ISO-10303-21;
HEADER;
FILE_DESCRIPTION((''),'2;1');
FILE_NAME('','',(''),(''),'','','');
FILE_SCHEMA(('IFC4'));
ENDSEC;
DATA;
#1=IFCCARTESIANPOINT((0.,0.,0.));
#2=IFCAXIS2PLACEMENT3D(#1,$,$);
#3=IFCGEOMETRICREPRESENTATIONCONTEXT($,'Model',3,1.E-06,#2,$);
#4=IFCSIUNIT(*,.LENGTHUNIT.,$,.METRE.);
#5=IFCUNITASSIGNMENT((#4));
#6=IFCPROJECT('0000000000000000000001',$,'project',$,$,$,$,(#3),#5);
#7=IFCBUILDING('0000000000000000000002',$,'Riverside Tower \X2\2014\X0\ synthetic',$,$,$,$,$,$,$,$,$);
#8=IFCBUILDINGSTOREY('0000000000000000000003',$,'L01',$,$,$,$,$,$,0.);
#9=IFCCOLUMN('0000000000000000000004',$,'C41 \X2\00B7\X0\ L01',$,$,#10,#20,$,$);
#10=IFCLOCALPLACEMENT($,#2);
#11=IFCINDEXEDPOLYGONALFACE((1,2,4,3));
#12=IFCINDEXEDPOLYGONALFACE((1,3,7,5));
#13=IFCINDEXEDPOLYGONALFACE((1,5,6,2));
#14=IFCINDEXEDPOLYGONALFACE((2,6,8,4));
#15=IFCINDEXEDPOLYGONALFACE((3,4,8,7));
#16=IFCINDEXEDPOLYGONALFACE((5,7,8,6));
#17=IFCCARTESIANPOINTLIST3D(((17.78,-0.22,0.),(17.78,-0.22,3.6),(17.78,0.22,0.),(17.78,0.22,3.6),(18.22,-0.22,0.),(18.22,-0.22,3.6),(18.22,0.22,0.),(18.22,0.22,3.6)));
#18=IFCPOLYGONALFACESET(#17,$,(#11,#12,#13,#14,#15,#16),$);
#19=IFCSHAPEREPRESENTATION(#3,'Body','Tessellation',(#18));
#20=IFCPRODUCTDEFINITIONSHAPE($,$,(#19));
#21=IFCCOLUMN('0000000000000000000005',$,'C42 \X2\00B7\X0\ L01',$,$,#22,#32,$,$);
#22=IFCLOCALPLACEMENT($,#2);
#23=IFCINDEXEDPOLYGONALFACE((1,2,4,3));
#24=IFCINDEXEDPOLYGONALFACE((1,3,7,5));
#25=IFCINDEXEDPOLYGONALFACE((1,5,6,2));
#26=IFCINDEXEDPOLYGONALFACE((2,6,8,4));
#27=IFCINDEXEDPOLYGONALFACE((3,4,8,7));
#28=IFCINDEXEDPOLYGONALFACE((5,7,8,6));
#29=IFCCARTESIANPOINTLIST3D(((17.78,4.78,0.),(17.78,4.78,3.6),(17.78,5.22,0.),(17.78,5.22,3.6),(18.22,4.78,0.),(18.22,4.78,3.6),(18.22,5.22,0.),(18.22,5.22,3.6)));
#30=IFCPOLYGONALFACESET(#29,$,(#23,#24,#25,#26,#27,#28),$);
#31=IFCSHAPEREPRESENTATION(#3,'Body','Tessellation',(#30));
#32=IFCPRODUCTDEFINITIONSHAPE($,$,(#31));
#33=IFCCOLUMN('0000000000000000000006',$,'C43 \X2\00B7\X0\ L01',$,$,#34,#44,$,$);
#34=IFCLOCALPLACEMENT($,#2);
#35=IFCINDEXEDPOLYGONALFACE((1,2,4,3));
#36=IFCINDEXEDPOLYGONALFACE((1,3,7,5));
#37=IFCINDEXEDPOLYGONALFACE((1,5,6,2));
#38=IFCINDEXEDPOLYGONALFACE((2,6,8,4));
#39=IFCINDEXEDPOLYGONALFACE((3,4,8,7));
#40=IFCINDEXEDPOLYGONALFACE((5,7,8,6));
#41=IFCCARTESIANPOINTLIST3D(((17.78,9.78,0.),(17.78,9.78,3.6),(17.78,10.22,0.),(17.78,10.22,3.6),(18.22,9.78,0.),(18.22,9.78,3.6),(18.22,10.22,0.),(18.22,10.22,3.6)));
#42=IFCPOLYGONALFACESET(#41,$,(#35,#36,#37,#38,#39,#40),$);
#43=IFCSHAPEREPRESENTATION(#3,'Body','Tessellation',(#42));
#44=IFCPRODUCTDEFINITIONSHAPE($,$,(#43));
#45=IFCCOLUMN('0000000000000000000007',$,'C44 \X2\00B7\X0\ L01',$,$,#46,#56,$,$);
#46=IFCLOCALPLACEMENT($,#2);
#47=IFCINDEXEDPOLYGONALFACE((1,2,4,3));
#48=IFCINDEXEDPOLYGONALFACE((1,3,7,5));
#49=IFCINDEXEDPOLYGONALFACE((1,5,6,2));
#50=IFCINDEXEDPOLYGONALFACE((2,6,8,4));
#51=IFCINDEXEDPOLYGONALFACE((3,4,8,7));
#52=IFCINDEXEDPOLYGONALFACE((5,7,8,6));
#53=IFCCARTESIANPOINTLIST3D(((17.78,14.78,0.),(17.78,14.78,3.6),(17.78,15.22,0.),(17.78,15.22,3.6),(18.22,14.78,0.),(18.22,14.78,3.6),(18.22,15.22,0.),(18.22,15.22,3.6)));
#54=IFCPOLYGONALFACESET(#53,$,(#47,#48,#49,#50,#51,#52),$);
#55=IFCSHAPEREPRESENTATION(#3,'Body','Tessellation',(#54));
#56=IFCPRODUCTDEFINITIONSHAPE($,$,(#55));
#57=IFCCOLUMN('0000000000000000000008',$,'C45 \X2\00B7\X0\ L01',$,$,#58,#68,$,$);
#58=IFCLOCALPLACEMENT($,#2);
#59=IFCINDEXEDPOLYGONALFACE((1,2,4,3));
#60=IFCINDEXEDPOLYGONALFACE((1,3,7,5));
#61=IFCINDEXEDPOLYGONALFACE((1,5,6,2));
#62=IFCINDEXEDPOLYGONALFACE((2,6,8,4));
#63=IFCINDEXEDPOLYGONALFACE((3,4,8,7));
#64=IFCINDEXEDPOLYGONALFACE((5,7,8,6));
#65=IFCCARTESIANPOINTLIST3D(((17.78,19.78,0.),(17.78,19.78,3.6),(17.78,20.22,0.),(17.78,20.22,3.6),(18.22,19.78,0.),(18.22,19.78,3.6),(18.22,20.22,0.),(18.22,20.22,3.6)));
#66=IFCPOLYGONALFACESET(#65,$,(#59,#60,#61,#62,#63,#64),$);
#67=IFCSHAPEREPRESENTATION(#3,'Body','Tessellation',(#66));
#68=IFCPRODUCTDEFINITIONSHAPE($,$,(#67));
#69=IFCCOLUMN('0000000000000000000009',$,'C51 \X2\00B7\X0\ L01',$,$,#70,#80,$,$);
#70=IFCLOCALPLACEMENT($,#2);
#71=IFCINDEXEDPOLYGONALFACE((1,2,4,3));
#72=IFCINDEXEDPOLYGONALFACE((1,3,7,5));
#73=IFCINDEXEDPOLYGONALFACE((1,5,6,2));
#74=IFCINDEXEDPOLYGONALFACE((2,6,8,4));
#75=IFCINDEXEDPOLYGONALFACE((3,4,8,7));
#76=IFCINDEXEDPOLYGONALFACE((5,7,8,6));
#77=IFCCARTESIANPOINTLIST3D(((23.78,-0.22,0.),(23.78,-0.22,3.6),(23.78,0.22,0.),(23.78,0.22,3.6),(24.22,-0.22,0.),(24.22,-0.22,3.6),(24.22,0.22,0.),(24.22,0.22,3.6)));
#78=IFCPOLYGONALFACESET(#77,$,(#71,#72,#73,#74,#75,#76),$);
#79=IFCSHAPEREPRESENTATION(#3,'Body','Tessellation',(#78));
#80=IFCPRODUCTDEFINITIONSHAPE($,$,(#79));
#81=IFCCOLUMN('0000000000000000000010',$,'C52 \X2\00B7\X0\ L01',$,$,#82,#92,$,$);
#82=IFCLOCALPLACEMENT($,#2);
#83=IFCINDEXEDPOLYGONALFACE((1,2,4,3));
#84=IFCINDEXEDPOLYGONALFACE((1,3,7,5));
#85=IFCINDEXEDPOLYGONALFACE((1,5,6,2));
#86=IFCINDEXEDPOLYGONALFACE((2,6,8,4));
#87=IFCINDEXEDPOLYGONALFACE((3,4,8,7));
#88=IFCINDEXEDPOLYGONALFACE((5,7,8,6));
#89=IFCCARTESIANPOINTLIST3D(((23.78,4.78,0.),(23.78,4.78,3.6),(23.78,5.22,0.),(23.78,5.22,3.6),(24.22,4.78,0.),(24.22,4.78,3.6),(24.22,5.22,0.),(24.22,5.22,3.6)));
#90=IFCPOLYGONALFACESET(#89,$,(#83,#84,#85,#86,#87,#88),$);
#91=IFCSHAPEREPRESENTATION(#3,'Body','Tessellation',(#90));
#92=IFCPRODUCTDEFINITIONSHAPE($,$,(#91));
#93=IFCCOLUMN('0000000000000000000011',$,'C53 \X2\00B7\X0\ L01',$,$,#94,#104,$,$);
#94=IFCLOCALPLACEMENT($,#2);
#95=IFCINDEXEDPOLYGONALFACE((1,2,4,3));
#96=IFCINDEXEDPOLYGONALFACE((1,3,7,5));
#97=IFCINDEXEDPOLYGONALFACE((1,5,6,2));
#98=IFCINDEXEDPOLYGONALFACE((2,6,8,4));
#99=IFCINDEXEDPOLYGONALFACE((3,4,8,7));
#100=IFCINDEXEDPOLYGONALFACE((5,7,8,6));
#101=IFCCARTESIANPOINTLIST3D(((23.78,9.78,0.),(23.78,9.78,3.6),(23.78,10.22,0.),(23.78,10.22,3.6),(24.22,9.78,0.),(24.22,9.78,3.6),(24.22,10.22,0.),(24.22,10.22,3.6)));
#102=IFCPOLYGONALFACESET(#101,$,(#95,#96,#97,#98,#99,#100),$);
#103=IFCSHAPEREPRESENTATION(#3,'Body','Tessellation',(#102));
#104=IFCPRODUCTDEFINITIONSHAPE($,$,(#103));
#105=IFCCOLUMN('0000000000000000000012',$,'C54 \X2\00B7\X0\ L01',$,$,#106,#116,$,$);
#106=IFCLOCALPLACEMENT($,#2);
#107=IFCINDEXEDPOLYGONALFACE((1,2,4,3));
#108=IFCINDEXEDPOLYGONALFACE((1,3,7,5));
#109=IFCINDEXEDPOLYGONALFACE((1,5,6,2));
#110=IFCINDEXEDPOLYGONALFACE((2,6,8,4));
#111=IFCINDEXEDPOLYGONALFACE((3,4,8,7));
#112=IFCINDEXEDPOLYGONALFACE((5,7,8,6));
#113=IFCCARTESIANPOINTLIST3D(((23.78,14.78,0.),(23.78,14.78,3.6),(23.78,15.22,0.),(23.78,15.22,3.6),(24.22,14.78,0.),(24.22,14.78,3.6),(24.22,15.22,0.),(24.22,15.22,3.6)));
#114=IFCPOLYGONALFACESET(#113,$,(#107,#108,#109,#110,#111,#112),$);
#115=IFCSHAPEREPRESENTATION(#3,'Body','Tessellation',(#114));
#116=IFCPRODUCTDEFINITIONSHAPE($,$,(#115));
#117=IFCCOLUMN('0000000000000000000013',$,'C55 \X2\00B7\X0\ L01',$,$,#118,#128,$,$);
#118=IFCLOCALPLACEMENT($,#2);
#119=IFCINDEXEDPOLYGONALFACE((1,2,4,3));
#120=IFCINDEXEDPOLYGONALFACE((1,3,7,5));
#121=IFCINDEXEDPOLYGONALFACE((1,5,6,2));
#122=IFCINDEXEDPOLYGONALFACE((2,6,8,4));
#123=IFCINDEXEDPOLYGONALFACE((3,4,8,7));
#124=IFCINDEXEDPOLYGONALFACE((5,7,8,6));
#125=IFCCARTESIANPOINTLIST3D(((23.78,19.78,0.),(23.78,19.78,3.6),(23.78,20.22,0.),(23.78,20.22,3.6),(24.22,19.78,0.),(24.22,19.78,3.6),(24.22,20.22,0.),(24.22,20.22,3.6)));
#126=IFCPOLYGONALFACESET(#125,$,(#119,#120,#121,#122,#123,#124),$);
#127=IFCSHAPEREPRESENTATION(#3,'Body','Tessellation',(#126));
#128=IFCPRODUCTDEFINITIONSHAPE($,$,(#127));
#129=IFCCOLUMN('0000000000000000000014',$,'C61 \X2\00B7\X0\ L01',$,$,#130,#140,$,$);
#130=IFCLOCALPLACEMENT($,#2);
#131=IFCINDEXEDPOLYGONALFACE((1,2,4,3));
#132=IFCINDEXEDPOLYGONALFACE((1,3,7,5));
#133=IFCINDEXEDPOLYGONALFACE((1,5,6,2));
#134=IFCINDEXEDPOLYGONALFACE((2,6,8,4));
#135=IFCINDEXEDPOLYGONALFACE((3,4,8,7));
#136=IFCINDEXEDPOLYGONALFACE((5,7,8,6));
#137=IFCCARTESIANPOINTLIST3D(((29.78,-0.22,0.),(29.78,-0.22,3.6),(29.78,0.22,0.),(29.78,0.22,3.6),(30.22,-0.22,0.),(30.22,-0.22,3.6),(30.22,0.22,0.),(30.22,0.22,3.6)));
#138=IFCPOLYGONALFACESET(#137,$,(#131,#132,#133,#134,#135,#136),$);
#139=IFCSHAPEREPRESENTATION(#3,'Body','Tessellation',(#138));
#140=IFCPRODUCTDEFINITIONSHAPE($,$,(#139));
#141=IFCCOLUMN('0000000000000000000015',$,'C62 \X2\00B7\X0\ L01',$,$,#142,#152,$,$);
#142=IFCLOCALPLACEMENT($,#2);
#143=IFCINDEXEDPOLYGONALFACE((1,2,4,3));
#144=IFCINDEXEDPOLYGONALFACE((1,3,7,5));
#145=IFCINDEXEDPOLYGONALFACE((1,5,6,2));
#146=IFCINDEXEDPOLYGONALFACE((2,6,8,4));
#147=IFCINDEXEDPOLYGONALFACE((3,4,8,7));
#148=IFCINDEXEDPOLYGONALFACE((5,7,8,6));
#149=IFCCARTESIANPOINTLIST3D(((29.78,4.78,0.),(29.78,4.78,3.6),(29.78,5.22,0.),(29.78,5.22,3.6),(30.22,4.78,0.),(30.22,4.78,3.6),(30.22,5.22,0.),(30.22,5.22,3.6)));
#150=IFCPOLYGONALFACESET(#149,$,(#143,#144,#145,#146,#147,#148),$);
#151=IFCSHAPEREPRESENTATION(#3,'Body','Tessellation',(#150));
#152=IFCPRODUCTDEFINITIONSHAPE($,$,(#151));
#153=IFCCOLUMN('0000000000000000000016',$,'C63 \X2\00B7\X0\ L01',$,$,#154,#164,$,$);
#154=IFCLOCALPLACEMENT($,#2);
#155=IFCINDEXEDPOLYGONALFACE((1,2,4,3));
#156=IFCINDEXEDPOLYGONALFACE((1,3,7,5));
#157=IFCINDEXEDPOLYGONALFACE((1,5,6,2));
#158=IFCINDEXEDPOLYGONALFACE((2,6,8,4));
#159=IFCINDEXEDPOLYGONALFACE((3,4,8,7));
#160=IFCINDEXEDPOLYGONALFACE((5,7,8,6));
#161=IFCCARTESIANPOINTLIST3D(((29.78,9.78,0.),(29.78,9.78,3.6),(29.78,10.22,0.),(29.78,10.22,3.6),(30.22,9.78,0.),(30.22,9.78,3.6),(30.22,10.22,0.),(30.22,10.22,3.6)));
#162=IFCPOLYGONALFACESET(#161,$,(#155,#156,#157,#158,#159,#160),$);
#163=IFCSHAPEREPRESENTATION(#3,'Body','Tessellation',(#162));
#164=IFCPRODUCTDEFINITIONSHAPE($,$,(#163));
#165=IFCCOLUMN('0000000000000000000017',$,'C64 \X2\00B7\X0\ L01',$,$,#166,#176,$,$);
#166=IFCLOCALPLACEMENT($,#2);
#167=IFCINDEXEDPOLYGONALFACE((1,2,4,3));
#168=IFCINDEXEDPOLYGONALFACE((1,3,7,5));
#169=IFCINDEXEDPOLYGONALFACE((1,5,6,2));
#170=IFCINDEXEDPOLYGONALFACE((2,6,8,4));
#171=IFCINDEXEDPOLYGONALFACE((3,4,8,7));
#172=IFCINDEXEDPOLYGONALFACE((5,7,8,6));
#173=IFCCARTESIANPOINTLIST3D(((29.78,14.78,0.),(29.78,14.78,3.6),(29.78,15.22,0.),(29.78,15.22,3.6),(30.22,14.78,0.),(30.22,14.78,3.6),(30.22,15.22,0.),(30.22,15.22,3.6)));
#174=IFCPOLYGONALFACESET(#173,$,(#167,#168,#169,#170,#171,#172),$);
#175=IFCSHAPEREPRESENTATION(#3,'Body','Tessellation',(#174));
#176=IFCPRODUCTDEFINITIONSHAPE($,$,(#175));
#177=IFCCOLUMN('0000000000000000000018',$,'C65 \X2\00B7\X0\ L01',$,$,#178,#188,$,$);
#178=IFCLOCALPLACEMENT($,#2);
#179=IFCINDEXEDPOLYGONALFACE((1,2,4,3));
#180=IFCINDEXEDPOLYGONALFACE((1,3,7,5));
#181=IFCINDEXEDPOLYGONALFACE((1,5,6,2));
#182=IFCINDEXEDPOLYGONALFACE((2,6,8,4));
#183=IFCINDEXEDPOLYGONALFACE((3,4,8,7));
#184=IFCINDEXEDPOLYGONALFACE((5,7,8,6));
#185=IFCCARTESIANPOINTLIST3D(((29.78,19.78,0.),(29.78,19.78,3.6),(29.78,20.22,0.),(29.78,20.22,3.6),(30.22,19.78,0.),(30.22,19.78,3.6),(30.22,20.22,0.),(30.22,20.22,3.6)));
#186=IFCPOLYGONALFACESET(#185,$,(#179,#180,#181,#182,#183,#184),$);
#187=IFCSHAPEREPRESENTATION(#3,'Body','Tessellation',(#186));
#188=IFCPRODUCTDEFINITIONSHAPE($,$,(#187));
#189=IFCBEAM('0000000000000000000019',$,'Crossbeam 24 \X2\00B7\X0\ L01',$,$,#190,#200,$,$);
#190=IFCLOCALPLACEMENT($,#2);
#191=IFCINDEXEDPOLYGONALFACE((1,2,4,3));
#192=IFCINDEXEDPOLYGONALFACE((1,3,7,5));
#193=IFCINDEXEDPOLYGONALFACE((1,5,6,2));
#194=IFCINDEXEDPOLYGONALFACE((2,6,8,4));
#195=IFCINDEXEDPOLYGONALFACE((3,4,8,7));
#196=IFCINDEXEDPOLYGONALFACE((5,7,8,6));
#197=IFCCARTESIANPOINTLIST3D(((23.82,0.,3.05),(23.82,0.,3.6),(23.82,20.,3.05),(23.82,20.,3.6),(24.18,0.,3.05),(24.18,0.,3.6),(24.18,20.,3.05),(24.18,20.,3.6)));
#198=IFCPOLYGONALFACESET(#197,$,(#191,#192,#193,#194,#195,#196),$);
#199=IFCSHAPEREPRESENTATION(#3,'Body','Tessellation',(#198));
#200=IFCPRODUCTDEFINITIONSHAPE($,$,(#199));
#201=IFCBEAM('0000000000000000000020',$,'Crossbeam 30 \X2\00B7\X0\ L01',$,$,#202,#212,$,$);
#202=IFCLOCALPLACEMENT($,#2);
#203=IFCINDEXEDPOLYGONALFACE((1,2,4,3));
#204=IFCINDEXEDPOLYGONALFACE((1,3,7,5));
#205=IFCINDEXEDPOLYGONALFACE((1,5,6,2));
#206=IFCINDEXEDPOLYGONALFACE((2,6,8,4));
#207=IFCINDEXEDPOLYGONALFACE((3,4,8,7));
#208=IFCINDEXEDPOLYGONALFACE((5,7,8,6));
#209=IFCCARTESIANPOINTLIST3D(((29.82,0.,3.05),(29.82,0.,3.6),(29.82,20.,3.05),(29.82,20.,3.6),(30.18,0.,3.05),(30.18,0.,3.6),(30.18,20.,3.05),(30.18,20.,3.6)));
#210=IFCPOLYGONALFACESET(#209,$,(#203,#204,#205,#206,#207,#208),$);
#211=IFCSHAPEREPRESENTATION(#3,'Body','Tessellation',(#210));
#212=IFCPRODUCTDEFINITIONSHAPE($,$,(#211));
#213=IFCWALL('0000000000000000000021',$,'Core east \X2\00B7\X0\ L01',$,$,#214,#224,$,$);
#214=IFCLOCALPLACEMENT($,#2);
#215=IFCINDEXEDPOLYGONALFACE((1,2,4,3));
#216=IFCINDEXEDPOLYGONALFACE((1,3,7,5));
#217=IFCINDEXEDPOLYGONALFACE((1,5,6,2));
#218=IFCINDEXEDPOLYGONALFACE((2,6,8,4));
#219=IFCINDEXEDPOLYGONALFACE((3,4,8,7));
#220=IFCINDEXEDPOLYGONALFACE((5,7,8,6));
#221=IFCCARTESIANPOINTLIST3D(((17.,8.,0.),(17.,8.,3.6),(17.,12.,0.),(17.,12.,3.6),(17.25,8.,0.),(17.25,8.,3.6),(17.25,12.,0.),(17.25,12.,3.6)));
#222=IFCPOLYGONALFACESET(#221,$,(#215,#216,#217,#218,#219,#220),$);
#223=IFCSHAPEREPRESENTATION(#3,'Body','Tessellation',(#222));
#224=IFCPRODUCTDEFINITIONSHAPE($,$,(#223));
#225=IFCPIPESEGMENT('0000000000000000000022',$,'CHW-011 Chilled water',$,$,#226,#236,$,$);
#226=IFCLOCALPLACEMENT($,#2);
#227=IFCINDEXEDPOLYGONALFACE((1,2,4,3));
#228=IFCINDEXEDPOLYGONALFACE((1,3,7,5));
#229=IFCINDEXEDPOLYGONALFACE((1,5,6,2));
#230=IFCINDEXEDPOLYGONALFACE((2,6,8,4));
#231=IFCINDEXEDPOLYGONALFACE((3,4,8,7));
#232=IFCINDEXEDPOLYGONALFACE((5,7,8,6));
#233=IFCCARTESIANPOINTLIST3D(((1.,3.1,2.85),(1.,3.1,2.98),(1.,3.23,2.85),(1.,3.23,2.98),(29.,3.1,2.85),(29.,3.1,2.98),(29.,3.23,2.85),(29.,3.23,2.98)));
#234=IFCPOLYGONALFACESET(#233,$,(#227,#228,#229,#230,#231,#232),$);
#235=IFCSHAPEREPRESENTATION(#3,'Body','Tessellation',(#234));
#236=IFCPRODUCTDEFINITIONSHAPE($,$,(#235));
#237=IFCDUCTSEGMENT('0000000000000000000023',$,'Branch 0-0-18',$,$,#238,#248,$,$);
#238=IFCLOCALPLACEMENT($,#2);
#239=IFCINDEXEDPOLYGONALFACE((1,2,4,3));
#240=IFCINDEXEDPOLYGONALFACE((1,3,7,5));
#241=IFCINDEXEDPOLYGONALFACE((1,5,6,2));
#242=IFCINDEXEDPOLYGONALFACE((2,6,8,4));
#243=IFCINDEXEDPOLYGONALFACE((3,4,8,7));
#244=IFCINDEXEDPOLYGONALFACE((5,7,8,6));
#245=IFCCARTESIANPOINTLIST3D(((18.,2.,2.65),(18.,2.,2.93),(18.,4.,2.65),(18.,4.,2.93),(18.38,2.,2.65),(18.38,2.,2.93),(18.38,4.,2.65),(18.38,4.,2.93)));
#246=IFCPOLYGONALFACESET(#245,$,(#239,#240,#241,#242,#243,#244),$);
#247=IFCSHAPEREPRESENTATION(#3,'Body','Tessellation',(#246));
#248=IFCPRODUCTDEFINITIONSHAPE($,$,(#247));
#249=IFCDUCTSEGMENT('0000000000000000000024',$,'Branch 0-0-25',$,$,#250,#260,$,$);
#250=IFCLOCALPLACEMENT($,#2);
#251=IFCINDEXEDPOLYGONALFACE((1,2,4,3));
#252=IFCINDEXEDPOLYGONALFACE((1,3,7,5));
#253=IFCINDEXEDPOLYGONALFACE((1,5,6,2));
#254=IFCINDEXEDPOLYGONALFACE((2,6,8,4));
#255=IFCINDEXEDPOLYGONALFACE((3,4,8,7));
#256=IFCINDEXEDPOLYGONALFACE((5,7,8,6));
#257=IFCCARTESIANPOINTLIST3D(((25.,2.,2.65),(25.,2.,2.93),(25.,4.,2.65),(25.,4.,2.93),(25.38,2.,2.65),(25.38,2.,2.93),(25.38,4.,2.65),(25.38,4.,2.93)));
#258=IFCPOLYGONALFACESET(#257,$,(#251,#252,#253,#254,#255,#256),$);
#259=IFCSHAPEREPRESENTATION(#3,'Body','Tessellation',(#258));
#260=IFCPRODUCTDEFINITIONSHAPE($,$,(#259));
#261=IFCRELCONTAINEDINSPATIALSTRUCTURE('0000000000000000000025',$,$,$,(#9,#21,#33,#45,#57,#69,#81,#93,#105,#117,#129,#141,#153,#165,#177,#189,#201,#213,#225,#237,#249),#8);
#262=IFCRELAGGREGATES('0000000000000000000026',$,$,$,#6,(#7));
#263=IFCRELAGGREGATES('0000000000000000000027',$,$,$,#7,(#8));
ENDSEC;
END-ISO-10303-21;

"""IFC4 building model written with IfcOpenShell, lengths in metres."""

from ifc_helpers import new_model, si_unit, frame, origin, place, context, project, spatial, rectangle, extrude, element, save


model = new_model("IFC4")

# Units and contexts
model_context = context("Model", 3, precision=1e-06, world=origin())
ifc_project = project(units=[si_unit("LENGTHUNIT", "METRE")], contexts=[model_context])

# Building, storey
building = spatial("IfcBuilding", under=ifc_project, Name="Riverside Tower — synthetic")
storey = spatial("IfcBuildingStorey", under=building, Name="L01", Elevation=0.0)

# Columns
for number, where, name in (
    (1, (18.0, 0.0, 0.0), "C41 · L01"),
    (2, (18.0, 5.0, 0.0), "C42 · L01"),
    (3, (18.0, 10.0, 0.0), "C43 · L01"),
    (4, (18.0, 15.0, 0.0), "C44 · L01"),
    (5, (18.0, 20.0, 0.0), "C45 · L01"),
    (6, (24.0, 0.0, 0.0), "C51 · L01"),
    (7, (24.0, 5.0, 0.0), "C52 · L01"),
    (8, (24.0, 10.0, 0.0), "C53 · L01"),
    (9, (24.0, 15.0, 0.0), "C54 · L01"),
    (10, (24.0, 20.0, 0.0), "C55 · L01"),
    (11, (30.0, 0.0, 0.0), "C61 · L01"),
    (12, (30.0, 5.0, 0.0), "C62 · L01"),
    (13, (30.0, 10.0, 0.0), "C63 · L01"),
    (14, (30.0, 15.0, 0.0), "C64 · L01"),
    (15, (30.0, 20.0, 0.0), "C65 · L01"),
):
    element("IfcColumn", number, at=place(None, frame(where)), inside=storey, Name=name, context=model_context, shape_type="SweptSolid", body=[
        extrude(rectangle(XDim=0.44, YDim=0.44), origin(), (0.0, 0.0, 1.0), 3.6),
    ])

# Beams
for number, where, name in (
    (16, (24.0, 10.0, 3.05), "Crossbeam 24 · L01"),
    (17, (30.0, 10.0, 3.05), "Crossbeam 30 · L01"),
):
    element("IfcBeam", number, at=place(None, frame(where)), inside=storey, Name=name, context=model_context, shape_type="SweptSolid", body=[
        extrude(rectangle(XDim=0.36, YDim=20.0), origin(), (0.0, 0.0, 1.0), 0.55),
    ])

# Wall
wall_placement = place(None, frame((17.125, 10.0, 0.0)))
element("IfcWall", 18, at=wall_placement, inside=storey, Name="Core east · L01", context=model_context, shape_type="SweptSolid", body=[
    extrude(rectangle(XDim=0.25, YDim=4.0), origin(), (0.0, 0.0, 1.0), 3.6),
])

# Pipe segment
pipe_segment_1_placement = place(None, frame((15.0, 3.165, 2.85)))
element("IfcPipeSegment", 19, at=pipe_segment_1_placement, inside=storey, Name="CHW-011 Chilled water", context=model_context, shape_type="SweptSolid", body=[
    extrude(rectangle(XDim=28.0, YDim=0.13), origin(), (0.0, 0.0, 1.0), 0.13),
])

# Duct segments
for number, where, name in (
    (20, (18.19, 3.0, 2.65), "Branch 0-0-18"),
    (21, (25.19, 3.0, 2.65), "Branch 0-0-25"),
):
    element("IfcDuctSegment", number, at=place(None, frame(where)), inside=storey, Name=name, context=model_context, shape_type="SweptSolid", body=[
        extrude(rectangle(XDim=0.38, YDim=2.0), origin(), (0.0, 0.0, 1.0), 0.28),
    ])

save(model, "model.ifc")
